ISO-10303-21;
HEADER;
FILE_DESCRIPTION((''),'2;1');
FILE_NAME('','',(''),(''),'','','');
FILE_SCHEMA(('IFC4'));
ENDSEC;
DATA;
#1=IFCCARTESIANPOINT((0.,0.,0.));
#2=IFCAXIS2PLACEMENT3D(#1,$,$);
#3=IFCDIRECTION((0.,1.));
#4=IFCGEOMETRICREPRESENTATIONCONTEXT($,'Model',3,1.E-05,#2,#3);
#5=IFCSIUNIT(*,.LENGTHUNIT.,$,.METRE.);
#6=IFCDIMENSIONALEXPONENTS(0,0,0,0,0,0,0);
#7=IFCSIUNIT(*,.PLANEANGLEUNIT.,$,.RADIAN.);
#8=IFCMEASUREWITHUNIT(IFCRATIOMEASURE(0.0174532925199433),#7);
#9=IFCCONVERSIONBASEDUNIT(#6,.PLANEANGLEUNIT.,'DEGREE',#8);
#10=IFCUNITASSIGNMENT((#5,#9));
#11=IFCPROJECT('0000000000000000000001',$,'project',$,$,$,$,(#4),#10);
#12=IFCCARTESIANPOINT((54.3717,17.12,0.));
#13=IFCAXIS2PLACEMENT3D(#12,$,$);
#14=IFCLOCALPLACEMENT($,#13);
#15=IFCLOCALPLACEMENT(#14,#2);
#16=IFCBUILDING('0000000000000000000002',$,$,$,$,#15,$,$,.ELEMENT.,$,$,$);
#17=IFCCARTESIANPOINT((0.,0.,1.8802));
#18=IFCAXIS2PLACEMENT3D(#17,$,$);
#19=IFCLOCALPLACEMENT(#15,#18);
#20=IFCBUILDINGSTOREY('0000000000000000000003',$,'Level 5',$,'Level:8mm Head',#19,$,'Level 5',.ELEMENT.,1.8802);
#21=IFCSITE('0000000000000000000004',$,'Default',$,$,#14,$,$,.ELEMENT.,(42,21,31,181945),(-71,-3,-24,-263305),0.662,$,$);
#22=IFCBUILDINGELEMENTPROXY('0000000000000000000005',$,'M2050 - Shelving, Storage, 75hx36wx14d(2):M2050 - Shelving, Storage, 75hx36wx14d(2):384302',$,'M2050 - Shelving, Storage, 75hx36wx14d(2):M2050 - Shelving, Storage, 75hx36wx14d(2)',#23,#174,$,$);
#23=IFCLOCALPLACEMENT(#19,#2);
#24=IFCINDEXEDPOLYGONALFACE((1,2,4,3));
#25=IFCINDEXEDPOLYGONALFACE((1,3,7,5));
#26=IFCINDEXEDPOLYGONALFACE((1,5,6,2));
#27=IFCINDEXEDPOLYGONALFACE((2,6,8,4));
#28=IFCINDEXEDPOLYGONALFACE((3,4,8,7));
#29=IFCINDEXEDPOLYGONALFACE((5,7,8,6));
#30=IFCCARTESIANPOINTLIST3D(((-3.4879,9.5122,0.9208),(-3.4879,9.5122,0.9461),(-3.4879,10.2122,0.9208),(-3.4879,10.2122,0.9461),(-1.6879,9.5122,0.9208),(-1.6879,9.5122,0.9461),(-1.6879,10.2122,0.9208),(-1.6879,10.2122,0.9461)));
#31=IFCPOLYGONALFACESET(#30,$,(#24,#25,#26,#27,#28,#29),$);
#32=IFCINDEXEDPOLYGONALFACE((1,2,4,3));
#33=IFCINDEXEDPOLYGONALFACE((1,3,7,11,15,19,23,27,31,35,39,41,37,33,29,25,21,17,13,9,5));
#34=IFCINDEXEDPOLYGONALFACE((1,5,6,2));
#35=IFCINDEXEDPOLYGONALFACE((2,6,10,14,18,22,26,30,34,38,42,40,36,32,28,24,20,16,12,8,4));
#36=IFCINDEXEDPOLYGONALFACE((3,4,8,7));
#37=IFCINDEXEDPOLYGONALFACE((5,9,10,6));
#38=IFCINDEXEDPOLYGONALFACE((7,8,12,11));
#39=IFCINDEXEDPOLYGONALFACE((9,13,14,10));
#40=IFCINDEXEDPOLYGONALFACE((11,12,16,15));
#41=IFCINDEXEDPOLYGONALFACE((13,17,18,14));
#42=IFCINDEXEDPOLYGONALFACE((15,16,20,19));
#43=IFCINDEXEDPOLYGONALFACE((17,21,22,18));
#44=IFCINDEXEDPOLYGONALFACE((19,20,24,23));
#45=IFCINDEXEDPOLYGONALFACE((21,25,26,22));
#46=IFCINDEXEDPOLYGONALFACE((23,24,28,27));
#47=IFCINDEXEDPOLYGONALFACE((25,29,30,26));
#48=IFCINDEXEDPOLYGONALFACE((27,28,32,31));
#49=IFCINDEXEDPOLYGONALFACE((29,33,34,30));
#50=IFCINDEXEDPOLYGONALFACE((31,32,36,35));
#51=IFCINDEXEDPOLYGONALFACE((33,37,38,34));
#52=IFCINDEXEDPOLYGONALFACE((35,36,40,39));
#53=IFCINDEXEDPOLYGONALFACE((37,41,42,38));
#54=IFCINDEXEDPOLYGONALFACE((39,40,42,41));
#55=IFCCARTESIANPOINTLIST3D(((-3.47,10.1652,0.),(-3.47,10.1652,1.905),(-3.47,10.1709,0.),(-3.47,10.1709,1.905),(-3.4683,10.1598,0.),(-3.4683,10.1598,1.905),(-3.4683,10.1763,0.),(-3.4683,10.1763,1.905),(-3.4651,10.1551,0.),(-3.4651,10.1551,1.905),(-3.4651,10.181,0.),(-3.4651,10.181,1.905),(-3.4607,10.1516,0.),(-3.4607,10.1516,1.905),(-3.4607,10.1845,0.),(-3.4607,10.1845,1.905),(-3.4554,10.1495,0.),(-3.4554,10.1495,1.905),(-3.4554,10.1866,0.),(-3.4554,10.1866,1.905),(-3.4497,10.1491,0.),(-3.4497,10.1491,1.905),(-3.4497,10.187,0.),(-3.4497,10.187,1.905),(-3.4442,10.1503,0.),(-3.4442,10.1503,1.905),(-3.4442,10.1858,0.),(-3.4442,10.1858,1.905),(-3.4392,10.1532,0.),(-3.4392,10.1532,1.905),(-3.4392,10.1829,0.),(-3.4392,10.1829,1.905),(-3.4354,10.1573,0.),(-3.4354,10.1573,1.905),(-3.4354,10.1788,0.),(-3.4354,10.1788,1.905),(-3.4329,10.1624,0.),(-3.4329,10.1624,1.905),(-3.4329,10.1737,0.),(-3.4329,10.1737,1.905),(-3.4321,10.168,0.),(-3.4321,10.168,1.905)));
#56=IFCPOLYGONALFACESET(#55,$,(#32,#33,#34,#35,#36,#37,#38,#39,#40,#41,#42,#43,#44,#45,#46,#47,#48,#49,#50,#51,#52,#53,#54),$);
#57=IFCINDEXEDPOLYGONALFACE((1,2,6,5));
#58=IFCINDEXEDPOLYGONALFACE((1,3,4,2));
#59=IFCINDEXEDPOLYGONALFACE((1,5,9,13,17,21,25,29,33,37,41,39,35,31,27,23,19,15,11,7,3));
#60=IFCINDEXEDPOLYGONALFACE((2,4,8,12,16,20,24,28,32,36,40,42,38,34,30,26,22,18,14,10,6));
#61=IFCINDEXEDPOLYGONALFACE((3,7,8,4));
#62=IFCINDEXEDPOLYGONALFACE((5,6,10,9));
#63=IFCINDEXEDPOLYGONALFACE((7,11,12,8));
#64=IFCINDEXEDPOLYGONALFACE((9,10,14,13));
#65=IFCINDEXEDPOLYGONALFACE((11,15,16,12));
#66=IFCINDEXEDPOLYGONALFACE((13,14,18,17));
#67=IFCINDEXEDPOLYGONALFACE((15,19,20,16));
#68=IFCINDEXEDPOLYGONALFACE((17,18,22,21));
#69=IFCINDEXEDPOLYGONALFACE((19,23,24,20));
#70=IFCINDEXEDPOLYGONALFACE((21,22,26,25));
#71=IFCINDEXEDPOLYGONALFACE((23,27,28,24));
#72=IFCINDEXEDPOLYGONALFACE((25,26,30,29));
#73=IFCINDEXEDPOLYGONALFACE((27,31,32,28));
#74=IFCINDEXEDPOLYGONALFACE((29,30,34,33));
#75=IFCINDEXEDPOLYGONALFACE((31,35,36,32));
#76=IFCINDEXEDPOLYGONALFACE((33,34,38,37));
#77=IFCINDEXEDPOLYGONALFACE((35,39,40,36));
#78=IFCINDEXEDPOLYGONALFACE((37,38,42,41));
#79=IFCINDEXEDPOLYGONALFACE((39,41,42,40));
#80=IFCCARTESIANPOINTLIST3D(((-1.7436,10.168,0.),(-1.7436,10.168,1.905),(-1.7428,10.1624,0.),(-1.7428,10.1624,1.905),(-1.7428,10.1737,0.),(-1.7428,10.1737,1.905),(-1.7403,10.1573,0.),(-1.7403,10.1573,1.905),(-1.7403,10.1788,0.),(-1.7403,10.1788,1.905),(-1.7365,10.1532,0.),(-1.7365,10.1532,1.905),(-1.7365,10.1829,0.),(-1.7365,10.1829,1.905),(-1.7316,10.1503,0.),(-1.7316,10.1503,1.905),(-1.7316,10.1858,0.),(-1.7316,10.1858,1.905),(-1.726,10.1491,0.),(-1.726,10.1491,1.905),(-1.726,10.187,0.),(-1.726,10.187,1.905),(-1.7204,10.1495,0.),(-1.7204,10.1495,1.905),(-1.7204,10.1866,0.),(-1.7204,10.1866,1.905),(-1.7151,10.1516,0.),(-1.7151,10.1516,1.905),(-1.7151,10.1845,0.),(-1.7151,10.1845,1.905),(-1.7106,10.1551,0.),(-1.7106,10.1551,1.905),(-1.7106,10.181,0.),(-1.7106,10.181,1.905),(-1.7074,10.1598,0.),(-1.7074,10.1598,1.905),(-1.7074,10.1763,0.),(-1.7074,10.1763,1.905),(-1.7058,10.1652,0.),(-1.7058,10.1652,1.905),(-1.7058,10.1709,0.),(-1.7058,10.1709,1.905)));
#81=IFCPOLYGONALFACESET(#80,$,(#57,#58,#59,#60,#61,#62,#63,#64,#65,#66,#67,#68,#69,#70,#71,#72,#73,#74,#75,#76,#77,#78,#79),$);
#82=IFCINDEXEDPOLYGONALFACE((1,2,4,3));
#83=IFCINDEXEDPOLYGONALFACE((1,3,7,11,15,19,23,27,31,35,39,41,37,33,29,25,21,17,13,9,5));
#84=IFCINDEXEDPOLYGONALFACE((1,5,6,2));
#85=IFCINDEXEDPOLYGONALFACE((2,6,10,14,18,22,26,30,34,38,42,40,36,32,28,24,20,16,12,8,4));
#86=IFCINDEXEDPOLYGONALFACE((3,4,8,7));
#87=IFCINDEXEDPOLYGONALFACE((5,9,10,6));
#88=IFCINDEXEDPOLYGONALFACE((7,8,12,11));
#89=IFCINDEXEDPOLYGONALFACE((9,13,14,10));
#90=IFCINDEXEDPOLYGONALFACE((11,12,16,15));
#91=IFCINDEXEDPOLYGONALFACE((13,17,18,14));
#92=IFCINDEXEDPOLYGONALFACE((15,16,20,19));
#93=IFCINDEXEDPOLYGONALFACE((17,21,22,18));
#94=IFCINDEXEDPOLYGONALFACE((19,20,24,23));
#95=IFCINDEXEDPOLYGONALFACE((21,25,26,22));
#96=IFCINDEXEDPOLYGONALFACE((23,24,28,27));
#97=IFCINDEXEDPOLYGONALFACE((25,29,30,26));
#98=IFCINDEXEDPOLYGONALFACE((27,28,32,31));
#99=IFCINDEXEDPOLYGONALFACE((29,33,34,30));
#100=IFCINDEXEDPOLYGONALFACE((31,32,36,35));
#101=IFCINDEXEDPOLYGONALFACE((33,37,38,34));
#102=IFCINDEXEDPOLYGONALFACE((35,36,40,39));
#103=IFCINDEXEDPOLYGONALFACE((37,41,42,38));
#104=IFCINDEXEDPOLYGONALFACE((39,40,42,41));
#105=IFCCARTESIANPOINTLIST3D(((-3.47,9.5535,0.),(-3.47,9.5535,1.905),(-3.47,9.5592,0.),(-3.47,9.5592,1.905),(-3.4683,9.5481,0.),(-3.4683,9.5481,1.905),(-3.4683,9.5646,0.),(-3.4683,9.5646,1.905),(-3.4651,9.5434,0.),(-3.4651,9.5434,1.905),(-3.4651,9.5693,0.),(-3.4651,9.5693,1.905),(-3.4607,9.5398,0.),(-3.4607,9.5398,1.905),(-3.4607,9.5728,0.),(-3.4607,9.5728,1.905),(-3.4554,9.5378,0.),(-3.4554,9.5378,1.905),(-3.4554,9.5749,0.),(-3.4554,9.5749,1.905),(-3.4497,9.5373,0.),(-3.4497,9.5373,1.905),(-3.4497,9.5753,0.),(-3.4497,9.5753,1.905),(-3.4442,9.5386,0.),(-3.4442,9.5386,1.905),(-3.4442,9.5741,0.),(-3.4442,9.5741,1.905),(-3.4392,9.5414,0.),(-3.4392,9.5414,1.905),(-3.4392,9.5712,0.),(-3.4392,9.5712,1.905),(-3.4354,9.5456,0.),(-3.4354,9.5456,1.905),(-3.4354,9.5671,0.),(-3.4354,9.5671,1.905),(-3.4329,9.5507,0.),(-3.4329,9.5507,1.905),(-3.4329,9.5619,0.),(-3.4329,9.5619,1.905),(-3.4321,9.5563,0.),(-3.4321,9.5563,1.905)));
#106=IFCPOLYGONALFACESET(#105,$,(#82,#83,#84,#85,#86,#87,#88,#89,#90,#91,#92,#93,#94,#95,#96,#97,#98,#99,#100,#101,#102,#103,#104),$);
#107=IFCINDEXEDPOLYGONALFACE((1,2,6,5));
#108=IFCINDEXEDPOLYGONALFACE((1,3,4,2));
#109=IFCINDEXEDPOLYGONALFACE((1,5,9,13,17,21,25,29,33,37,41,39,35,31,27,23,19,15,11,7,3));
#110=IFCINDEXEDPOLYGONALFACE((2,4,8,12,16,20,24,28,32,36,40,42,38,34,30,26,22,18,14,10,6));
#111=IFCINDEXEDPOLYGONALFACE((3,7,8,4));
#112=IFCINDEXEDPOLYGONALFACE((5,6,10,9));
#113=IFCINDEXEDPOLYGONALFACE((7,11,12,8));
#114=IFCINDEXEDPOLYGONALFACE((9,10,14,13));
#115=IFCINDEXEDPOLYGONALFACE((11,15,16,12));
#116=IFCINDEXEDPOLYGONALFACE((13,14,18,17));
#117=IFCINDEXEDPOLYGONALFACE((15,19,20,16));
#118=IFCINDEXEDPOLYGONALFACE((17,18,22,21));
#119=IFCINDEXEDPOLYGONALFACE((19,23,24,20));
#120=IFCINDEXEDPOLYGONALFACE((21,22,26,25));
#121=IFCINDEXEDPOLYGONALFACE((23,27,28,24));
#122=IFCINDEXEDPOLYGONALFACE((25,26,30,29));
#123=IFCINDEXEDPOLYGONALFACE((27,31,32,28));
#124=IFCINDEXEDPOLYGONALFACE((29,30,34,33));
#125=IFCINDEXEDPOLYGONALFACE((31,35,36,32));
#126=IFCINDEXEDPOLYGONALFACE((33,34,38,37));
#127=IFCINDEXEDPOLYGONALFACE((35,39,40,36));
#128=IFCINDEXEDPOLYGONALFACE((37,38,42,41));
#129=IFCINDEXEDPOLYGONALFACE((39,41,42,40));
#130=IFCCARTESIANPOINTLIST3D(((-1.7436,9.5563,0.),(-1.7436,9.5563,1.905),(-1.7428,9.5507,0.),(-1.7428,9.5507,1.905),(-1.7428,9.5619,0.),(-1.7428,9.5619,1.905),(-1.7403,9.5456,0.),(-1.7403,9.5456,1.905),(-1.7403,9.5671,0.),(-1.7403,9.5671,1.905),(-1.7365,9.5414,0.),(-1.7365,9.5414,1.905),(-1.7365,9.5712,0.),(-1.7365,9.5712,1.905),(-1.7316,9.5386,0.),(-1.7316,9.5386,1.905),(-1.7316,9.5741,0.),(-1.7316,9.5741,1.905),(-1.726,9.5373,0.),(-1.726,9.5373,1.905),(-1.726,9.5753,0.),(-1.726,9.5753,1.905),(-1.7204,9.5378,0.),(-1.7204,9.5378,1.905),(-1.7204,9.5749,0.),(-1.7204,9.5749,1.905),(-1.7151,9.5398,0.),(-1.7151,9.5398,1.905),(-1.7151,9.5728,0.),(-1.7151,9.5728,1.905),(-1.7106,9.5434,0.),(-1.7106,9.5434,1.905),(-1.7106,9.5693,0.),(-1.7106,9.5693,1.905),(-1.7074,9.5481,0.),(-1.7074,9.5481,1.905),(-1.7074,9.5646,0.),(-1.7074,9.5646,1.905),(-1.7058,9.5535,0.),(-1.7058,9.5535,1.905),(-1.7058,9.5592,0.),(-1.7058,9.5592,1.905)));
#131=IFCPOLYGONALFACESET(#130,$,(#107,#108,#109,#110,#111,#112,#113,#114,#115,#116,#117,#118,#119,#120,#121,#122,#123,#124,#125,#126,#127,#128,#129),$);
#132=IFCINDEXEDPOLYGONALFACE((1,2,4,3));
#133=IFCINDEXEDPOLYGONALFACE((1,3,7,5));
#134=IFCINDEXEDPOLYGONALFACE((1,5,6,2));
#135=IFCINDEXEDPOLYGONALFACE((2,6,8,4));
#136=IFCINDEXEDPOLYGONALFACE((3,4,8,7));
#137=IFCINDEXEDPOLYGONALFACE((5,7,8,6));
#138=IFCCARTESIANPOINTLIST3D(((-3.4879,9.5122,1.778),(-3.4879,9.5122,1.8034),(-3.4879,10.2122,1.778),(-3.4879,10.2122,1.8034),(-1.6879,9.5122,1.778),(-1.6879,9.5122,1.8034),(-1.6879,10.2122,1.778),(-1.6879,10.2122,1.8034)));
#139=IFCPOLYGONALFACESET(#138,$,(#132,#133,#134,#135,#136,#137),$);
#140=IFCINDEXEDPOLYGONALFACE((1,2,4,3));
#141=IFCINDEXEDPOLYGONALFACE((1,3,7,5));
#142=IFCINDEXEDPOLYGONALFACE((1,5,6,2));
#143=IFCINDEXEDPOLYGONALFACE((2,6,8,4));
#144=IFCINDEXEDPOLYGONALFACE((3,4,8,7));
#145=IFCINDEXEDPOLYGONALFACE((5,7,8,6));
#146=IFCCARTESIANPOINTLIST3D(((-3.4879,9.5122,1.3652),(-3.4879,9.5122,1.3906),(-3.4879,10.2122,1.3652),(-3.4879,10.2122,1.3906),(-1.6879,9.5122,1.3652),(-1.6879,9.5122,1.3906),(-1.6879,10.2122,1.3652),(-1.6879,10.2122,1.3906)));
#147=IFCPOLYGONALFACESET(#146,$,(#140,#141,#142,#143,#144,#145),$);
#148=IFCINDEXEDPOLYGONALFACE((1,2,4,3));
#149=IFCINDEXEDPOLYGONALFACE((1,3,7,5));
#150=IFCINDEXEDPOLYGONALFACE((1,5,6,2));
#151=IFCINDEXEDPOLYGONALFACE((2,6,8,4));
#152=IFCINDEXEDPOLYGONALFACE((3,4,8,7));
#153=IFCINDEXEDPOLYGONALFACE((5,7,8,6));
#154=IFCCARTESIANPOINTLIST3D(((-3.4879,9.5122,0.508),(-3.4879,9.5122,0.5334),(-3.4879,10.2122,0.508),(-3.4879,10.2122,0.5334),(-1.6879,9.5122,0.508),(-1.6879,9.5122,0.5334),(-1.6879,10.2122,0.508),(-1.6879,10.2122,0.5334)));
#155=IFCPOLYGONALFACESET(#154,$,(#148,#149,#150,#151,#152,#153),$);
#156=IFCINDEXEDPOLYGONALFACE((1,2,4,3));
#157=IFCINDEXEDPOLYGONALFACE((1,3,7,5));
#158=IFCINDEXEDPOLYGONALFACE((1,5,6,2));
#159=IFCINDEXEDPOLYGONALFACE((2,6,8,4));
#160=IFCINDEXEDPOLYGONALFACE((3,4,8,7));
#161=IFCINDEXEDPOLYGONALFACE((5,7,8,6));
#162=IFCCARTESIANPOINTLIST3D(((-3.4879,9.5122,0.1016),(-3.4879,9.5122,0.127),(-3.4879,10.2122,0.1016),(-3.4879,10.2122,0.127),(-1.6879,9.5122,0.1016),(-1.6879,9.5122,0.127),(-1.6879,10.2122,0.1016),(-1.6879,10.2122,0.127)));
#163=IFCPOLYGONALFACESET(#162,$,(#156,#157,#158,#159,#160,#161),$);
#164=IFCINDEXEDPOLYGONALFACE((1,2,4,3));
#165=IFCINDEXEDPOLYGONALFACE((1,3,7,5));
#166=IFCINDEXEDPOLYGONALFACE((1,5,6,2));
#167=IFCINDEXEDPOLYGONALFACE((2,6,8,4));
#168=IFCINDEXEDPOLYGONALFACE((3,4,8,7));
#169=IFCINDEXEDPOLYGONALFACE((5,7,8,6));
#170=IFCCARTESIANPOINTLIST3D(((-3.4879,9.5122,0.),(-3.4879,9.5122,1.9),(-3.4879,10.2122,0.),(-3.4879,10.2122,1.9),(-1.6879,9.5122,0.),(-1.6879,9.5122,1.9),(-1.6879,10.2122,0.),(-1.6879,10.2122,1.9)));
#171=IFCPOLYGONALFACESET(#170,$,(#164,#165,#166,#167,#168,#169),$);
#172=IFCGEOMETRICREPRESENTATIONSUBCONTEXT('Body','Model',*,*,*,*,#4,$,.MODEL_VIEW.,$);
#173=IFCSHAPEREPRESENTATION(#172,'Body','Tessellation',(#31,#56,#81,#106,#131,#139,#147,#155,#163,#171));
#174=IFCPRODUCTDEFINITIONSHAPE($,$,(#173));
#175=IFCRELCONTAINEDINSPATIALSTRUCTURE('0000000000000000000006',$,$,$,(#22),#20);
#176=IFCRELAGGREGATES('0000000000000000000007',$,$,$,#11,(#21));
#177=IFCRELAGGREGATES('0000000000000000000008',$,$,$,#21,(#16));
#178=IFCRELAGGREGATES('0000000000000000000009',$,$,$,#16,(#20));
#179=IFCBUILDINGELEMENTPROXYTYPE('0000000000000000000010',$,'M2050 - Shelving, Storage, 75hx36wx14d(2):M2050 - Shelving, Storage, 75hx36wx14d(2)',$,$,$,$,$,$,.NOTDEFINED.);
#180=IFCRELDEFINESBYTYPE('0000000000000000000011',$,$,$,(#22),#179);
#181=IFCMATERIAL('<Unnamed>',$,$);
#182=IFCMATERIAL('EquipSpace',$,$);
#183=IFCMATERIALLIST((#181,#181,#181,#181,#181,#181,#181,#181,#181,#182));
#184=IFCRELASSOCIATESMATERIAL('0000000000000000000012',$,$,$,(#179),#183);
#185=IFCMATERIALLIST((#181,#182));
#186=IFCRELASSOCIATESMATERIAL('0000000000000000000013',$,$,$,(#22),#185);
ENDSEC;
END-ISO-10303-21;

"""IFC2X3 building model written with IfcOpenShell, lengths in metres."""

from ifc_helpers import new_model, entity, si_unit, converted_unit, direction, frame, frame_2d, origin, origin_2d_with_axis, place, context, subcontext, project, spatial, rectangle, circle, extrude, source, transform, mapped, material, material_list, type_object, type_shapes, element, save


model = new_model("IFC2X3")

# Units and contexts
model_context = context("Model", 3, precision=1e-05, world=origin(), true_north=direction((0.0, 1.0)))
body_context = subcontext(model_context, "Body", "Model", "MODEL_VIEW")
ifc_project = project(units=[si_unit("LENGTHUNIT", "METRE"), converted_unit("PLANEANGLEUNIT", "DEGREE", entity("IfcRatioMeasure", 0.0174532925199433), si_unit("PLANEANGLEUNIT", "RADIAN"), dimensions=[0, 0, 0, 0, 0, 0, 0])], contexts=[model_context])

# Site, building, storey
site_placement = place(None, frame((54.3717, 17.12, 0.0)))
site = spatial("IfcSite", under=ifc_project, at=site_placement, Name="Default", CompositionType="ELEMENT", RefLatitude=(42, 21, 31, 181945), RefLongitude=(-71, -3, -24, -263305), RefElevation=0.662)
building_placement = place(site_placement, origin())
building = spatial("IfcBuilding", under=site, at=building_placement, CompositionType="ELEMENT")
storey_placement = place(building_placement, frame((0.0, 0.0, 1.8802)))
storey = spatial("IfcBuildingStorey", under=building, at=storey_placement, Name="Level 5", ObjectType="Level:8mm Head", LongName="Level 5", CompositionType="ELEMENT", Elevation=1.8802)

# Building element proxy
ifc_material_1 = material(Name="<Unnamed>")
ifc_material_2 = material(Name="EquipSpace")
ifc_material_list_1 = material_list([ifc_material_1, ifc_material_1, ifc_material_1, ifc_material_1, ifc_material_1, ifc_material_1, ifc_material_1, ifc_material_1, ifc_material_1, ifc_material_2])
building_element_proxy_type = type_object("IfcBuildingElementProxyType", Name="M2050 - Shelving, Storage, 75hx36wx14d(2):M2050 - Shelving, Storage, 75hx36wx14d(2)", PredefinedType="NOTDEFINED", material=ifc_material_list_1)
shared_shape = source(origin(), body_context, "Body", "SweptSolid", [
    extrude(rectangle(XDim=1.8, YDim=0.7, at=origin_2d_with_axis()), frame((0.0, 0.0, 0.9207), z_axis=(0.0, 0.0, 1.0), x_axis=(-1.0, 0.0, 0.0)), (0.0, 0.0, 1.0), 0.0254),
    extrude(circle(Radius=0.0191, at=origin_2d_with_axis()), frame((0.8633, -0.3059, 0.0), z_axis=(0.0, 0.0, 1.0), x_axis=(-1.0, 0.0, 0.0)), (0.0, 0.0, 1.0), 1.905),
    extrude(circle(Radius=0.0191, at=origin_2d_with_axis()), frame((-0.8633, -0.3059, 0.0)), (0.0, 0.0, 1.0), 1.905),
    extrude(circle(Radius=0.0191, at=origin_2d_with_axis()), frame((0.8633, 0.3059, 0.0), z_axis=(0.0, 0.0, 1.0), x_axis=(-1.0, 0.0, 0.0)), (0.0, 0.0, 1.0), 1.905),
    extrude(circle(Radius=0.0191, at=origin_2d_with_axis()), frame((-0.8633, 0.3059, 0.0)), (0.0, 0.0, 1.0), 1.905),
    extrude(rectangle(XDim=1.8, YDim=0.7, at=origin_2d_with_axis()), frame((0.0, 0.0, 1.778), z_axis=(0.0, 0.0, 1.0), x_axis=(-1.0, 0.0, 0.0)), (0.0, 0.0, 1.0), 0.0254),
    extrude(rectangle(XDim=1.8, YDim=0.7, at=origin_2d_with_axis()), frame((0.0, 0.0, 1.3653), z_axis=(0.0, 0.0, 1.0), x_axis=(-1.0, 0.0, 0.0)), (0.0, 0.0, 1.0), 0.0254),
    extrude(rectangle(XDim=1.8, YDim=0.7, at=origin_2d_with_axis()), frame((0.0, 0.0, 0.508), z_axis=(0.0, 0.0, 1.0), x_axis=(-1.0, 0.0, 0.0)), (0.0, 0.0, 1.0), 0.0254),
    extrude(rectangle(XDim=1.8, YDim=0.7, at=origin_2d_with_axis()), frame((0.0, 0.0, 0.1016), z_axis=(0.0, 0.0, 1.0), x_axis=(-1.0, 0.0, 0.0)), (0.0, 0.0, 1.0), 0.0254),
    extrude(rectangle(XDim=0.7, YDim=1.8, at=frame_2d((0.0, 0.18), x_axis=(1.0, 0.0))), frame((-0.18, 0.0, 0.0), z_axis=(0.0, 0.0, 1.0), x_axis=(0.0, -1.0, 0.0)), (0.0, 0.0, 1.0), 1.9),
])
type_shapes(building_element_proxy_type, [shared_shape])
ifc_material_list_2 = material_list([ifc_material_1, ifc_material_2])
proxy_1_placement = place(storey_placement, frame((-2.5879, 9.8622, 0.0), z_axis=(0.0, 0.0, 1.0), x_axis=(-1.0, 0.0, 0.0)))
element("IfcBuildingElementProxy", 1, at=proxy_1_placement, inside=storey, type_object=building_element_proxy_type, material=ifc_material_list_2, Name="M2050 - Shelving, Storage, 75hx36wx14d(2):M2050 - Shelving, Storage, 75hx36wx14d(2):384302", ObjectType="M2050 - Shelving, Storage, 75hx36wx14d(2):M2050 - Shelving, Storage, 75hx36wx14d(2)", context=body_context, shape_type="MappedRepresentation", body=[
    mapped(shared_shape, transform((0.0, 0.0, 0.0), scale=1.0)),
])

save(model, "model.ifc")
